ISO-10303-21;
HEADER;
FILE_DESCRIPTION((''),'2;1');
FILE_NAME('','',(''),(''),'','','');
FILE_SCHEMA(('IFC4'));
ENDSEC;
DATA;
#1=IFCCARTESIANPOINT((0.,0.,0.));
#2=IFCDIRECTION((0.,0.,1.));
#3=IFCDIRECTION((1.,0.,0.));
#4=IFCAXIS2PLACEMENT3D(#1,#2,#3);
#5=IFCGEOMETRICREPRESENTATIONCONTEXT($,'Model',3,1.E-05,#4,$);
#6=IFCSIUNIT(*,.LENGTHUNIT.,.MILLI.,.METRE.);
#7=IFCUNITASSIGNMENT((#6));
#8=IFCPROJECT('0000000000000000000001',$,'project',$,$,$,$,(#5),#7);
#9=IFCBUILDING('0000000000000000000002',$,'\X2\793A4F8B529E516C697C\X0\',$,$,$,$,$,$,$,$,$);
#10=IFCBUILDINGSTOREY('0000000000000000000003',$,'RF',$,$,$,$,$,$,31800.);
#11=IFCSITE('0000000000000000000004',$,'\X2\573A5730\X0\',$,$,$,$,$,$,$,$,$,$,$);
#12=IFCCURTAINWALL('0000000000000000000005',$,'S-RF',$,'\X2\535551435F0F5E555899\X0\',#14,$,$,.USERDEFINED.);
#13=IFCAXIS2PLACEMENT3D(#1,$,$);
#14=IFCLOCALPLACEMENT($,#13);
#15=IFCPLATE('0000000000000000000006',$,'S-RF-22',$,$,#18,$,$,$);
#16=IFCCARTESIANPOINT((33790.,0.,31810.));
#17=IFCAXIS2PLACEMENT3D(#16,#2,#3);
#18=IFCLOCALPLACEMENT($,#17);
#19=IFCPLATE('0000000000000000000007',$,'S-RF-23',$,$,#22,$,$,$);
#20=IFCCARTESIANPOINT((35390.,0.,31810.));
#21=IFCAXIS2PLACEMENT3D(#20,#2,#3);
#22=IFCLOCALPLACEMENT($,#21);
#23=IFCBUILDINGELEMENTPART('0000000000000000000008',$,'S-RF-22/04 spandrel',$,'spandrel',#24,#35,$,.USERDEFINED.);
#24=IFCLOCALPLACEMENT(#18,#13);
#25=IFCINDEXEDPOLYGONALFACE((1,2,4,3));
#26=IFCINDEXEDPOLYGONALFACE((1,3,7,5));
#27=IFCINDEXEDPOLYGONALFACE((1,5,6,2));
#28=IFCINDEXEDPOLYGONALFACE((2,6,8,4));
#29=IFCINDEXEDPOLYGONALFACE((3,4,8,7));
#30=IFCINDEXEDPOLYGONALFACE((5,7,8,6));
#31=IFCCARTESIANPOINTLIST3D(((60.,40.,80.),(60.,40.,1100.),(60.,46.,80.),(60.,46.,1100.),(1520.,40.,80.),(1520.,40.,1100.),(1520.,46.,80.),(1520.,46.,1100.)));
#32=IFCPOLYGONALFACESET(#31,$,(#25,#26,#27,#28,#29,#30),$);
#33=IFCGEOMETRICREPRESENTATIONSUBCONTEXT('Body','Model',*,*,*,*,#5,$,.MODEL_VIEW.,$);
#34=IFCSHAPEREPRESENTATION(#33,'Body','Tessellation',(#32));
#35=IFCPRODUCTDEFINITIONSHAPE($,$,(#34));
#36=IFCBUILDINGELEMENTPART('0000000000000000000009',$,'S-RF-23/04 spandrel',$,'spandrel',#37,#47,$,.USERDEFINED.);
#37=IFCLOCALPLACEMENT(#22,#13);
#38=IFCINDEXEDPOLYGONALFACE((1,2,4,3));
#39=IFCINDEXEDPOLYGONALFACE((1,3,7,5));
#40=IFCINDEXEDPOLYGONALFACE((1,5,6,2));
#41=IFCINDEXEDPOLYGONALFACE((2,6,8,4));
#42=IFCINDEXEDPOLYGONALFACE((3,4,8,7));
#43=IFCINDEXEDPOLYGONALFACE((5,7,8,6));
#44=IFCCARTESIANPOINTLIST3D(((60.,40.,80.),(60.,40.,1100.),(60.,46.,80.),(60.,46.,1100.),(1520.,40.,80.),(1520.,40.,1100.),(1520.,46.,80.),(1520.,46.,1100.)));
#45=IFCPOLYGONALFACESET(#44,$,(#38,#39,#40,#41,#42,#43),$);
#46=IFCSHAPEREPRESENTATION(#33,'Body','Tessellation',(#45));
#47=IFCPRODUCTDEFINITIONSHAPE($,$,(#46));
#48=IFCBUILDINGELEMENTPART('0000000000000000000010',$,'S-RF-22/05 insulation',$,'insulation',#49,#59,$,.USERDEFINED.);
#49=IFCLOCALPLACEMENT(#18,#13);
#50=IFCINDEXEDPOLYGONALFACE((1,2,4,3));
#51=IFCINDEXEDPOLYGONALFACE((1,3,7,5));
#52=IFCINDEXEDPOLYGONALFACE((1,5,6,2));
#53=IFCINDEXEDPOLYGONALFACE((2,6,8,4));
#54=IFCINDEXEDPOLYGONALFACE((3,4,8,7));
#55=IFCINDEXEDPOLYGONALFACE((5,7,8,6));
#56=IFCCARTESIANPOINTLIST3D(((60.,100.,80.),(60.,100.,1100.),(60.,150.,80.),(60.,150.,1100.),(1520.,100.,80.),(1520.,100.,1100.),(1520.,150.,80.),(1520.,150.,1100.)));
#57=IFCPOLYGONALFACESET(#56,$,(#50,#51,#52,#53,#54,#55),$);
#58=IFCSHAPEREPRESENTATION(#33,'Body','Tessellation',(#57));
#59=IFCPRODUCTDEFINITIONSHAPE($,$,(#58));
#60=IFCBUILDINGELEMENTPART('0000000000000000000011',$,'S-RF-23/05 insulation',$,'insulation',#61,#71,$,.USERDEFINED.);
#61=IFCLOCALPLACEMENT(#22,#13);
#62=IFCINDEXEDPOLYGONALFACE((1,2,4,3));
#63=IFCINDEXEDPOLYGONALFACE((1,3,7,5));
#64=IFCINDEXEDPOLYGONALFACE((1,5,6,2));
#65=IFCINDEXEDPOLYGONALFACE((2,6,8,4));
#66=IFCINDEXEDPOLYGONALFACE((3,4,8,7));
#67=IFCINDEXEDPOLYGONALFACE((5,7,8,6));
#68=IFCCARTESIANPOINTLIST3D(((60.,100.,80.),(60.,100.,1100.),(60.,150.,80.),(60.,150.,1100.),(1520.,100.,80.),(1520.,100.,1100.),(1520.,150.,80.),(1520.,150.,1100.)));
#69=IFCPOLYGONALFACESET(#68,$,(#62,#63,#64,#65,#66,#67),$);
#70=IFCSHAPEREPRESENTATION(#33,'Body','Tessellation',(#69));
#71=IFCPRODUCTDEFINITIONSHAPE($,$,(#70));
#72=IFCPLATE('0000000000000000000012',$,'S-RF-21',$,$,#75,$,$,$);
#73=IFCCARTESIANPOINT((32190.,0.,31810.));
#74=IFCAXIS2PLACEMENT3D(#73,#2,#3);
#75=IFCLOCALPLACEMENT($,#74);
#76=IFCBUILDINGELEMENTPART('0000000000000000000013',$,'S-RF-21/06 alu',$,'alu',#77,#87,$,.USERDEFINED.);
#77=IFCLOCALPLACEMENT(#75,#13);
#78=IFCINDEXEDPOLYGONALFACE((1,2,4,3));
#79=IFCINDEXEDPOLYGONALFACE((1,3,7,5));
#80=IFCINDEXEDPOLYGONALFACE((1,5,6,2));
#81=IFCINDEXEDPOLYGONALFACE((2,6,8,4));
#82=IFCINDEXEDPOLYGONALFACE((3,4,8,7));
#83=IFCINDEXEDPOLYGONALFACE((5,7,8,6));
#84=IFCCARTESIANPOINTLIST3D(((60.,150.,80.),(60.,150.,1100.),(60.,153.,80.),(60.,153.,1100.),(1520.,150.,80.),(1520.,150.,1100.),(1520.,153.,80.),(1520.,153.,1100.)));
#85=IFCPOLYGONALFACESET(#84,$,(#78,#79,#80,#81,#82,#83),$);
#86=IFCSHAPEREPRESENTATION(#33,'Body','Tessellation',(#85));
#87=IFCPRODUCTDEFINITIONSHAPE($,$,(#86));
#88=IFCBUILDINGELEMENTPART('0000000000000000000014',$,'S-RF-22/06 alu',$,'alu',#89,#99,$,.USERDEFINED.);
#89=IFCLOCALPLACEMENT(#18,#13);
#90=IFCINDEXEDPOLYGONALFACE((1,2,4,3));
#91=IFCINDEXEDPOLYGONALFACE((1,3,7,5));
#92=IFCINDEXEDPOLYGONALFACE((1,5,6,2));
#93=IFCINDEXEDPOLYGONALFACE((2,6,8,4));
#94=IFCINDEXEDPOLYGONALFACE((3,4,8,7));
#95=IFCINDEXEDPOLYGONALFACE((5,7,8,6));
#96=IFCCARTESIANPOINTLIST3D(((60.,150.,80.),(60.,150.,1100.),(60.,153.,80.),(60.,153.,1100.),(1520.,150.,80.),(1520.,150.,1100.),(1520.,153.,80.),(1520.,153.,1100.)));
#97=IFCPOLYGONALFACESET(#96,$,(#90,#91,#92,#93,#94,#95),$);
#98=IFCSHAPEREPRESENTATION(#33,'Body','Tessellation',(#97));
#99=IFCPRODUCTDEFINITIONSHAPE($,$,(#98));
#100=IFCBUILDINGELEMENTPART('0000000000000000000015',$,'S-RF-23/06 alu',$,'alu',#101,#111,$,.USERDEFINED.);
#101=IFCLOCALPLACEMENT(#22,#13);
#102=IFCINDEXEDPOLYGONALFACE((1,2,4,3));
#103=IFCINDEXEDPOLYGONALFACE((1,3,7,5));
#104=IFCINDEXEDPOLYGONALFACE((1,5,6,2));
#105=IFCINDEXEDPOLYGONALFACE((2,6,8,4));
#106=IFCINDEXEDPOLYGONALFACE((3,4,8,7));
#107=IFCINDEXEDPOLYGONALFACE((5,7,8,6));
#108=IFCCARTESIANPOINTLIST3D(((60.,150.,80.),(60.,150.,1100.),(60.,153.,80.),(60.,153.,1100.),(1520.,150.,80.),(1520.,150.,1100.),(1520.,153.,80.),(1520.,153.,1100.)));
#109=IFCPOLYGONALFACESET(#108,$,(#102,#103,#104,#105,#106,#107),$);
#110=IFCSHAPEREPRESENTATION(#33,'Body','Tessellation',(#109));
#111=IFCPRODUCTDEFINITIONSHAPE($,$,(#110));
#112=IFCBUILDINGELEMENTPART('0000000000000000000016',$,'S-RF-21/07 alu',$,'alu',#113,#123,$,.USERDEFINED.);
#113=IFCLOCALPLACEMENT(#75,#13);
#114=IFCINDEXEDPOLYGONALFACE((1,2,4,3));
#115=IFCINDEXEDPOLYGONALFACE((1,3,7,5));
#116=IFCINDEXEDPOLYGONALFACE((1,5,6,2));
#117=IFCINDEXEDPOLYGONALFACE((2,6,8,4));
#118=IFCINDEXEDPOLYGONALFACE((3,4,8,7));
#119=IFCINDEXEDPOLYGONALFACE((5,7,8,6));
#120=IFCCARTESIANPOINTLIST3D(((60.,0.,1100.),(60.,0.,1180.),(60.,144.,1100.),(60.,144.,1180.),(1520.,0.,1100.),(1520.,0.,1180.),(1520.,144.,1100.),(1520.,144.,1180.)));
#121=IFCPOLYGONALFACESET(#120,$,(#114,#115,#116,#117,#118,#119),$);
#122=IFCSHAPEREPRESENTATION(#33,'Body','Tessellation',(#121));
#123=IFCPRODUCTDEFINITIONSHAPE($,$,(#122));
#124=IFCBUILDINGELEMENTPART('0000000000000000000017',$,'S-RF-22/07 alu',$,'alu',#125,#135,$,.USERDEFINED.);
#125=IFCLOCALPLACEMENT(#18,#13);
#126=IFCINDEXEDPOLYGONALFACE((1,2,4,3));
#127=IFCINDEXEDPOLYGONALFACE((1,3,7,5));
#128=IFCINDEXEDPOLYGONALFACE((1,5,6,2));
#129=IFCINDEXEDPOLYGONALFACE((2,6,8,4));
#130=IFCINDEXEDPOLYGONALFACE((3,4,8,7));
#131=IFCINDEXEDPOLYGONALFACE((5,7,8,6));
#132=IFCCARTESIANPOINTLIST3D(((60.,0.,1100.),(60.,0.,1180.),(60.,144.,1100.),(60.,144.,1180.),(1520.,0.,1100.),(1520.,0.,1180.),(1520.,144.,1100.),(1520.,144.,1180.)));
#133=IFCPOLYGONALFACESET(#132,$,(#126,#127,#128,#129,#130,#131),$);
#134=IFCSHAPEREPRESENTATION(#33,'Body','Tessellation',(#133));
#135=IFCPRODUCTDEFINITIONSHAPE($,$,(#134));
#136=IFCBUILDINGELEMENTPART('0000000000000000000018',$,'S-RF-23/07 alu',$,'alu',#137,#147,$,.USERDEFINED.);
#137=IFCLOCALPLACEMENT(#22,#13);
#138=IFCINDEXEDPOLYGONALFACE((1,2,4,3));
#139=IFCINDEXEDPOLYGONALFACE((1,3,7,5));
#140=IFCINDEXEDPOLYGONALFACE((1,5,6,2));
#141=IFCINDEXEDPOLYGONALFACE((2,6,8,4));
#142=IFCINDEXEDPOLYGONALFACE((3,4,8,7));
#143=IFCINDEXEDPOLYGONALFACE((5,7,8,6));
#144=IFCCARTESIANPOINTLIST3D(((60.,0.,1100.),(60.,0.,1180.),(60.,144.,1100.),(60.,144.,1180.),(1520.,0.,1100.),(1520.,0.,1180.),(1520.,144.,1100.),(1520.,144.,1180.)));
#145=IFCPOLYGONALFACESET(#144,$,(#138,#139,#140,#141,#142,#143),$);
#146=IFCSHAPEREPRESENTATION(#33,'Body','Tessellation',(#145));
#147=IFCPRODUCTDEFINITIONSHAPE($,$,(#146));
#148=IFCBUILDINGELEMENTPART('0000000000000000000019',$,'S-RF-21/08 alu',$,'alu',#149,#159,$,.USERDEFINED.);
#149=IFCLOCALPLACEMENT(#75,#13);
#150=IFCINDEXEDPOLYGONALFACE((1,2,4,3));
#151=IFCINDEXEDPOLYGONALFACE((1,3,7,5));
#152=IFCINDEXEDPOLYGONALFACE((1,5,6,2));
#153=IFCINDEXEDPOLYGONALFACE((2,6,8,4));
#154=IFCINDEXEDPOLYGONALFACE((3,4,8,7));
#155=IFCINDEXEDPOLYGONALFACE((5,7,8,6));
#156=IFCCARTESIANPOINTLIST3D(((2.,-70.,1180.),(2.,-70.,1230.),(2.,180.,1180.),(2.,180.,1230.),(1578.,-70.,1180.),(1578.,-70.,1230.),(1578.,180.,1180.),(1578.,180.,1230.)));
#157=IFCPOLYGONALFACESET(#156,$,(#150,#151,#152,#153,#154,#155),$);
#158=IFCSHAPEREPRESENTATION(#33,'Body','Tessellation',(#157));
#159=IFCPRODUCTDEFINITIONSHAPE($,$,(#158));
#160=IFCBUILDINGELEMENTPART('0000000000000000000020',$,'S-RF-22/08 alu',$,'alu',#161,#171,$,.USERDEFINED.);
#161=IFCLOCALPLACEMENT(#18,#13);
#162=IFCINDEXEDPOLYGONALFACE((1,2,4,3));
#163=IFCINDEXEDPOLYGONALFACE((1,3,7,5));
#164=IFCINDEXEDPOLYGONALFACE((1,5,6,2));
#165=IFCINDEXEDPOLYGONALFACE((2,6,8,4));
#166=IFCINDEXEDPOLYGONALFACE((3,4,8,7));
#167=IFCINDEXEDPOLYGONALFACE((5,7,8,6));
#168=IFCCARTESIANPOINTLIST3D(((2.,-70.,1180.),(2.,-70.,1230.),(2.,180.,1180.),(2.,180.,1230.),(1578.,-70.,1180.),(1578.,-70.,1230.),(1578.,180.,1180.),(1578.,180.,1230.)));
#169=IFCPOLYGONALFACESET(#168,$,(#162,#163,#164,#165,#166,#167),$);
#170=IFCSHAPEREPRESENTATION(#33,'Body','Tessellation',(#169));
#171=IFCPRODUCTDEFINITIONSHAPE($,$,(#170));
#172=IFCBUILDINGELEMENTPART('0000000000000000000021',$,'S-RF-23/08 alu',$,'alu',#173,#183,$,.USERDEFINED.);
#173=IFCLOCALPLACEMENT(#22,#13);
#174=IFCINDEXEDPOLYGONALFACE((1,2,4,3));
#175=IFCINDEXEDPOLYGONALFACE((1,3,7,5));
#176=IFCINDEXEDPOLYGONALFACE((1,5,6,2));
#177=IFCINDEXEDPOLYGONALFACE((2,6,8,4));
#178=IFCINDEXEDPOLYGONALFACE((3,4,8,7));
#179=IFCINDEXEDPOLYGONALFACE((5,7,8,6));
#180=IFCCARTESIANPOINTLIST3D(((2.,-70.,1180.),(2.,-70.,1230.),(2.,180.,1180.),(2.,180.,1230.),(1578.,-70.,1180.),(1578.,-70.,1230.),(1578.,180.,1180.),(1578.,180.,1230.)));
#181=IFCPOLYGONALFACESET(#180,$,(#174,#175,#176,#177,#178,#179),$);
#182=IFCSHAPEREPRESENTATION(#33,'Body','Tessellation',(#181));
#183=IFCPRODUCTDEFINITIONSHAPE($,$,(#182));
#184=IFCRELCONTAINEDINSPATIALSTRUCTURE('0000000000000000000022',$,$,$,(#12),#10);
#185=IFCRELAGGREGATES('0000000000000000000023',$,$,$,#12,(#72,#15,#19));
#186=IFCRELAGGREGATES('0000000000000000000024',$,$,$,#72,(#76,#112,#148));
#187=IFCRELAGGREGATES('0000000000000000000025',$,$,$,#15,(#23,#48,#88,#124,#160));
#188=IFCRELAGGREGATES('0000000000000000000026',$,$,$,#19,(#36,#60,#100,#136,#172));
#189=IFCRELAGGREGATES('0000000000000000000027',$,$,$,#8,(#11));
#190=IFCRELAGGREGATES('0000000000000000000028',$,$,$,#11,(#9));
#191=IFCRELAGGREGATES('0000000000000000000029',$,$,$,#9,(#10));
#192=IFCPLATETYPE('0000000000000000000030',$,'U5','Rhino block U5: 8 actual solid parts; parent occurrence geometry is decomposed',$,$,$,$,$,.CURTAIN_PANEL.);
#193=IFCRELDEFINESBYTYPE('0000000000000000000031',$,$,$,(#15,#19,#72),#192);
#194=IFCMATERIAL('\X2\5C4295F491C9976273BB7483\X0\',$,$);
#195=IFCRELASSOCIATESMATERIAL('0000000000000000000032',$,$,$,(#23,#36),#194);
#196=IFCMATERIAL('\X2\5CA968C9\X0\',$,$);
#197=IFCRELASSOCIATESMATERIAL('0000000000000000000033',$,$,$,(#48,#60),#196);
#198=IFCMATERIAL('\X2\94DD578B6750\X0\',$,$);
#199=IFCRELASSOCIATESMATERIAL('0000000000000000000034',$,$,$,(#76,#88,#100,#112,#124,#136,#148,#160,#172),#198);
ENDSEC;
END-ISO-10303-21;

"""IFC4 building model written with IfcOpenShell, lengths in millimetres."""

from ifc_helpers import new_model, si_unit, frame, frame_2d, origin, origin_with_axes, place, context, subcontext, project, spatial, rectangle, extrude, source, transform, mapped, material, type_object, element, aggregate, save


model = new_model("IFC4")

# Units and contexts
model_context = context("Model", 3, precision=1e-05, world=origin_with_axes())
body_context = subcontext(model_context, "Body", "Model", "MODEL_VIEW")
ifc_project = project(units=[si_unit("LENGTHUNIT", "METRE", prefix="MILLI")], contexts=[model_context])

# Site, building, storey
site = spatial("IfcSite", under=ifc_project, Name="场地")
building = spatial("IfcBuilding", under=site, Name="示例办公楼")
storey = spatial("IfcBuildingStorey", under=building, Name="RF", Elevation=31800.0)

# Curtain wall, plates, building element parts
curtain_wall = element("IfcCurtainWall", 1, inside=storey, Name="S-RF", ObjectType="单元式幕墙", PredefinedType="USERDEFINED")
plate_type = type_object("IfcPlateType", Name="U5", Description="Rhino block U5: 8 actual solid parts; parent occurrence geometry is decomposed", PredefinedType="CURTAIN_PANEL")
plate_1_placement = place(None, frame((33790.0, 0.0, 31810.0), z_axis=(0.0, 0.0, 1.0), x_axis=(1.0, 0.0, 0.0)))
plate_1 = element("IfcPlate", 2, at=plate_1_placement, type_object=plate_type, Name="S-RF-22")
ifc_material_1 = material(Name="铝型材")
plate_2_placement = place(None, frame((35390.0, 0.0, 31810.0), z_axis=(0.0, 0.0, 1.0), x_axis=(1.0, 0.0, 0.0)))
plate_2 = element("IfcPlate", 3, at=plate_2_placement, type_object=plate_type, Name="S-RF-23")
ifc_material_2 = material(Name="层间釉面玻璃")
shared_shape_1 = source(origin(), body_context, "Body", "SweptSolid", [
    extrude(rectangle(XDim=1460.0, YDim=6.0, at=frame_2d((790.0, 43.0))), frame((0.0, 0.0, 80.0)), (0.0, 0.0, 1.0), 1020.0),
])
building_element_part_1_placement = place(plate_1_placement, origin())
building_element_part_1 = element("IfcBuildingElementPart", 4, at=building_element_part_1_placement, material=ifc_material_2, Name="S-RF-22/04 spandrel", ObjectType="spandrel", PredefinedType="USERDEFINED", context=body_context, shape_type="MappedRepresentation", body=[
    mapped(shared_shape_1, transform((0.0, 0.0, 0.0))),
])
building_element_part_2_placement = place(plate_2_placement, origin())
building_element_part_2 = element("IfcBuildingElementPart", 5, at=building_element_part_2_placement, material=ifc_material_2, Name="S-RF-23/04 spandrel", ObjectType="spandrel", PredefinedType="USERDEFINED", context=body_context, shape_type="MappedRepresentation", body=[
    mapped(shared_shape_1, transform((0.0, 0.0, 0.0))),
])
ifc_material_3 = material(Name="岩棉")
shared_shape_2 = source(origin(), body_context, "Body", "SweptSolid", [
    extrude(rectangle(XDim=1460.0, YDim=50.0, at=frame_2d((790.0, 125.0))), frame((0.0, 0.0, 80.0)), (0.0, 0.0, 1.0), 1020.0),
])
building_element_part_3_placement = place(plate_1_placement, origin())
building_element_part_3 = element("IfcBuildingElementPart", 6, at=building_element_part_3_placement, material=ifc_material_3, Name="S-RF-22/05 insulation", ObjectType="insulation", PredefinedType="USERDEFINED", context=body_context, shape_type="MappedRepresentation", body=[
    mapped(shared_shape_2, transform((0.0, 0.0, 0.0))),
])
building_element_part_4_placement = place(plate_2_placement, origin())
building_element_part_4 = element("IfcBuildingElementPart", 7, at=building_element_part_4_placement, material=ifc_material_3, Name="S-RF-23/05 insulation", ObjectType="insulation", PredefinedType="USERDEFINED", context=body_context, shape_type="MappedRepresentation", body=[
    mapped(shared_shape_2, transform((0.0, 0.0, 0.0))),
])
plate_3_placement = place(None, frame((32190.0, 0.0, 31810.0), z_axis=(0.0, 0.0, 1.0), x_axis=(1.0, 0.0, 0.0)))
plate_3 = element("IfcPlate", 8, at=plate_3_placement, type_object=plate_type, Name="S-RF-21")
aggregate(curtain_wall, [plate_3, plate_1, plate_2])
shared_shape_3 = source(origin(), body_context, "Body", "SweptSolid", [
    extrude(rectangle(XDim=1460.0, YDim=3.0, at=frame_2d((790.0, 151.5))), frame((0.0, 0.0, 80.0)), (0.0, 0.0, 1.0), 1020.0),
])
building_element_part_5_placement = place(plate_3_placement, origin())
building_element_part_5 = element("IfcBuildingElementPart", 9, at=building_element_part_5_placement, material=ifc_material_1, Name="S-RF-21/06 alu", ObjectType="alu", PredefinedType="USERDEFINED", context=body_context, shape_type="MappedRepresentation", body=[
    mapped(shared_shape_3, transform((0.0, 0.0, 0.0))),
])
building_element_part_6_placement = place(plate_1_placement, origin())
building_element_part_6 = element("IfcBuildingElementPart", 10, at=building_element_part_6_placement, material=ifc_material_1, Name="S-RF-22/06 alu", ObjectType="alu", PredefinedType="USERDEFINED", context=body_context, shape_type="MappedRepresentation", body=[
    mapped(shared_shape_3, transform((0.0, 0.0, 0.0))),
])
building_element_part_7_placement = place(plate_2_placement, origin())
building_element_part_7 = element("IfcBuildingElementPart", 11, at=building_element_part_7_placement, material=ifc_material_1, Name="S-RF-23/06 alu", ObjectType="alu", PredefinedType="USERDEFINED", context=body_context, shape_type="MappedRepresentation", body=[
    mapped(shared_shape_3, transform((0.0, 0.0, 0.0))),
])
shared_shape_4 = source(origin(), body_context, "Body", "SweptSolid", [
    extrude(rectangle(XDim=1460.0, YDim=144.0, at=frame_2d((790.0, 72.0))), frame((0.0, 0.0, 1100.0)), (0.0, 0.0, 1.0), 80.0),
])
building_element_part_8_placement = place(plate_3_placement, origin())
building_element_part_8 = element("IfcBuildingElementPart", 12, at=building_element_part_8_placement, material=ifc_material_1, Name="S-RF-21/07 alu", ObjectType="alu", PredefinedType="USERDEFINED", context=body_context, shape_type="MappedRepresentation", body=[
    mapped(shared_shape_4, transform((0.0, 0.0, 0.0))),
])
building_element_part_9_placement = place(plate_1_placement, origin())
building_element_part_9 = element("IfcBuildingElementPart", 13, at=building_element_part_9_placement, material=ifc_material_1, Name="S-RF-22/07 alu", ObjectType="alu", PredefinedType="USERDEFINED", context=body_context, shape_type="MappedRepresentation", body=[
    mapped(shared_shape_4, transform((0.0, 0.0, 0.0))),
])
building_element_part_10_placement = place(plate_2_placement, origin())
building_element_part_10 = element("IfcBuildingElementPart", 14, at=building_element_part_10_placement, material=ifc_material_1, Name="S-RF-23/07 alu", ObjectType="alu", PredefinedType="USERDEFINED", context=body_context, shape_type="MappedRepresentation", body=[
    mapped(shared_shape_4, transform((0.0, 0.0, 0.0))),
])
shared_shape_5 = source(origin(), body_context, "Body", "SweptSolid", [
    extrude(rectangle(XDim=1576.0, YDim=250.0, at=frame_2d((790.0, 55.0))), frame((0.0, 0.0, 1180.0)), (0.0, 0.0, 1.0), 50.0),
])
building_element_part_11_placement = place(plate_3_placement, origin())
building_element_part_11 = element("IfcBuildingElementPart", 15, at=building_element_part_11_placement, material=ifc_material_1, Name="S-RF-21/08 alu", ObjectType="alu", PredefinedType="USERDEFINED", context=body_context, shape_type="MappedRepresentation", body=[
    mapped(shared_shape_5, transform((0.0, 0.0, 0.0))),
])
aggregate(plate_3, [building_element_part_5, building_element_part_8, building_element_part_11])
building_element_part_12_placement = place(plate_1_placement, origin())
building_element_part_12 = element("IfcBuildingElementPart", 16, at=building_element_part_12_placement, material=ifc_material_1, Name="S-RF-22/08 alu", ObjectType="alu", PredefinedType="USERDEFINED", context=body_context, shape_type="MappedRepresentation", body=[
    mapped(shared_shape_5, transform((0.0, 0.0, 0.0))),
])
aggregate(plate_1, [building_element_part_1, building_element_part_3, building_element_part_6, building_element_part_9, building_element_part_12])
building_element_part_13_placement = place(plate_2_placement, origin())
building_element_part_13 = element("IfcBuildingElementPart", 17, at=building_element_part_13_placement, material=ifc_material_1, Name="S-RF-23/08 alu", ObjectType="alu", PredefinedType="USERDEFINED", context=body_context, shape_type="MappedRepresentation", body=[
    mapped(shared_shape_5, transform((0.0, 0.0, 0.0))),
])
aggregate(plate_2, [building_element_part_2, building_element_part_4, building_element_part_7, building_element_part_10, building_element_part_13])

save(model, "model.ifc")
